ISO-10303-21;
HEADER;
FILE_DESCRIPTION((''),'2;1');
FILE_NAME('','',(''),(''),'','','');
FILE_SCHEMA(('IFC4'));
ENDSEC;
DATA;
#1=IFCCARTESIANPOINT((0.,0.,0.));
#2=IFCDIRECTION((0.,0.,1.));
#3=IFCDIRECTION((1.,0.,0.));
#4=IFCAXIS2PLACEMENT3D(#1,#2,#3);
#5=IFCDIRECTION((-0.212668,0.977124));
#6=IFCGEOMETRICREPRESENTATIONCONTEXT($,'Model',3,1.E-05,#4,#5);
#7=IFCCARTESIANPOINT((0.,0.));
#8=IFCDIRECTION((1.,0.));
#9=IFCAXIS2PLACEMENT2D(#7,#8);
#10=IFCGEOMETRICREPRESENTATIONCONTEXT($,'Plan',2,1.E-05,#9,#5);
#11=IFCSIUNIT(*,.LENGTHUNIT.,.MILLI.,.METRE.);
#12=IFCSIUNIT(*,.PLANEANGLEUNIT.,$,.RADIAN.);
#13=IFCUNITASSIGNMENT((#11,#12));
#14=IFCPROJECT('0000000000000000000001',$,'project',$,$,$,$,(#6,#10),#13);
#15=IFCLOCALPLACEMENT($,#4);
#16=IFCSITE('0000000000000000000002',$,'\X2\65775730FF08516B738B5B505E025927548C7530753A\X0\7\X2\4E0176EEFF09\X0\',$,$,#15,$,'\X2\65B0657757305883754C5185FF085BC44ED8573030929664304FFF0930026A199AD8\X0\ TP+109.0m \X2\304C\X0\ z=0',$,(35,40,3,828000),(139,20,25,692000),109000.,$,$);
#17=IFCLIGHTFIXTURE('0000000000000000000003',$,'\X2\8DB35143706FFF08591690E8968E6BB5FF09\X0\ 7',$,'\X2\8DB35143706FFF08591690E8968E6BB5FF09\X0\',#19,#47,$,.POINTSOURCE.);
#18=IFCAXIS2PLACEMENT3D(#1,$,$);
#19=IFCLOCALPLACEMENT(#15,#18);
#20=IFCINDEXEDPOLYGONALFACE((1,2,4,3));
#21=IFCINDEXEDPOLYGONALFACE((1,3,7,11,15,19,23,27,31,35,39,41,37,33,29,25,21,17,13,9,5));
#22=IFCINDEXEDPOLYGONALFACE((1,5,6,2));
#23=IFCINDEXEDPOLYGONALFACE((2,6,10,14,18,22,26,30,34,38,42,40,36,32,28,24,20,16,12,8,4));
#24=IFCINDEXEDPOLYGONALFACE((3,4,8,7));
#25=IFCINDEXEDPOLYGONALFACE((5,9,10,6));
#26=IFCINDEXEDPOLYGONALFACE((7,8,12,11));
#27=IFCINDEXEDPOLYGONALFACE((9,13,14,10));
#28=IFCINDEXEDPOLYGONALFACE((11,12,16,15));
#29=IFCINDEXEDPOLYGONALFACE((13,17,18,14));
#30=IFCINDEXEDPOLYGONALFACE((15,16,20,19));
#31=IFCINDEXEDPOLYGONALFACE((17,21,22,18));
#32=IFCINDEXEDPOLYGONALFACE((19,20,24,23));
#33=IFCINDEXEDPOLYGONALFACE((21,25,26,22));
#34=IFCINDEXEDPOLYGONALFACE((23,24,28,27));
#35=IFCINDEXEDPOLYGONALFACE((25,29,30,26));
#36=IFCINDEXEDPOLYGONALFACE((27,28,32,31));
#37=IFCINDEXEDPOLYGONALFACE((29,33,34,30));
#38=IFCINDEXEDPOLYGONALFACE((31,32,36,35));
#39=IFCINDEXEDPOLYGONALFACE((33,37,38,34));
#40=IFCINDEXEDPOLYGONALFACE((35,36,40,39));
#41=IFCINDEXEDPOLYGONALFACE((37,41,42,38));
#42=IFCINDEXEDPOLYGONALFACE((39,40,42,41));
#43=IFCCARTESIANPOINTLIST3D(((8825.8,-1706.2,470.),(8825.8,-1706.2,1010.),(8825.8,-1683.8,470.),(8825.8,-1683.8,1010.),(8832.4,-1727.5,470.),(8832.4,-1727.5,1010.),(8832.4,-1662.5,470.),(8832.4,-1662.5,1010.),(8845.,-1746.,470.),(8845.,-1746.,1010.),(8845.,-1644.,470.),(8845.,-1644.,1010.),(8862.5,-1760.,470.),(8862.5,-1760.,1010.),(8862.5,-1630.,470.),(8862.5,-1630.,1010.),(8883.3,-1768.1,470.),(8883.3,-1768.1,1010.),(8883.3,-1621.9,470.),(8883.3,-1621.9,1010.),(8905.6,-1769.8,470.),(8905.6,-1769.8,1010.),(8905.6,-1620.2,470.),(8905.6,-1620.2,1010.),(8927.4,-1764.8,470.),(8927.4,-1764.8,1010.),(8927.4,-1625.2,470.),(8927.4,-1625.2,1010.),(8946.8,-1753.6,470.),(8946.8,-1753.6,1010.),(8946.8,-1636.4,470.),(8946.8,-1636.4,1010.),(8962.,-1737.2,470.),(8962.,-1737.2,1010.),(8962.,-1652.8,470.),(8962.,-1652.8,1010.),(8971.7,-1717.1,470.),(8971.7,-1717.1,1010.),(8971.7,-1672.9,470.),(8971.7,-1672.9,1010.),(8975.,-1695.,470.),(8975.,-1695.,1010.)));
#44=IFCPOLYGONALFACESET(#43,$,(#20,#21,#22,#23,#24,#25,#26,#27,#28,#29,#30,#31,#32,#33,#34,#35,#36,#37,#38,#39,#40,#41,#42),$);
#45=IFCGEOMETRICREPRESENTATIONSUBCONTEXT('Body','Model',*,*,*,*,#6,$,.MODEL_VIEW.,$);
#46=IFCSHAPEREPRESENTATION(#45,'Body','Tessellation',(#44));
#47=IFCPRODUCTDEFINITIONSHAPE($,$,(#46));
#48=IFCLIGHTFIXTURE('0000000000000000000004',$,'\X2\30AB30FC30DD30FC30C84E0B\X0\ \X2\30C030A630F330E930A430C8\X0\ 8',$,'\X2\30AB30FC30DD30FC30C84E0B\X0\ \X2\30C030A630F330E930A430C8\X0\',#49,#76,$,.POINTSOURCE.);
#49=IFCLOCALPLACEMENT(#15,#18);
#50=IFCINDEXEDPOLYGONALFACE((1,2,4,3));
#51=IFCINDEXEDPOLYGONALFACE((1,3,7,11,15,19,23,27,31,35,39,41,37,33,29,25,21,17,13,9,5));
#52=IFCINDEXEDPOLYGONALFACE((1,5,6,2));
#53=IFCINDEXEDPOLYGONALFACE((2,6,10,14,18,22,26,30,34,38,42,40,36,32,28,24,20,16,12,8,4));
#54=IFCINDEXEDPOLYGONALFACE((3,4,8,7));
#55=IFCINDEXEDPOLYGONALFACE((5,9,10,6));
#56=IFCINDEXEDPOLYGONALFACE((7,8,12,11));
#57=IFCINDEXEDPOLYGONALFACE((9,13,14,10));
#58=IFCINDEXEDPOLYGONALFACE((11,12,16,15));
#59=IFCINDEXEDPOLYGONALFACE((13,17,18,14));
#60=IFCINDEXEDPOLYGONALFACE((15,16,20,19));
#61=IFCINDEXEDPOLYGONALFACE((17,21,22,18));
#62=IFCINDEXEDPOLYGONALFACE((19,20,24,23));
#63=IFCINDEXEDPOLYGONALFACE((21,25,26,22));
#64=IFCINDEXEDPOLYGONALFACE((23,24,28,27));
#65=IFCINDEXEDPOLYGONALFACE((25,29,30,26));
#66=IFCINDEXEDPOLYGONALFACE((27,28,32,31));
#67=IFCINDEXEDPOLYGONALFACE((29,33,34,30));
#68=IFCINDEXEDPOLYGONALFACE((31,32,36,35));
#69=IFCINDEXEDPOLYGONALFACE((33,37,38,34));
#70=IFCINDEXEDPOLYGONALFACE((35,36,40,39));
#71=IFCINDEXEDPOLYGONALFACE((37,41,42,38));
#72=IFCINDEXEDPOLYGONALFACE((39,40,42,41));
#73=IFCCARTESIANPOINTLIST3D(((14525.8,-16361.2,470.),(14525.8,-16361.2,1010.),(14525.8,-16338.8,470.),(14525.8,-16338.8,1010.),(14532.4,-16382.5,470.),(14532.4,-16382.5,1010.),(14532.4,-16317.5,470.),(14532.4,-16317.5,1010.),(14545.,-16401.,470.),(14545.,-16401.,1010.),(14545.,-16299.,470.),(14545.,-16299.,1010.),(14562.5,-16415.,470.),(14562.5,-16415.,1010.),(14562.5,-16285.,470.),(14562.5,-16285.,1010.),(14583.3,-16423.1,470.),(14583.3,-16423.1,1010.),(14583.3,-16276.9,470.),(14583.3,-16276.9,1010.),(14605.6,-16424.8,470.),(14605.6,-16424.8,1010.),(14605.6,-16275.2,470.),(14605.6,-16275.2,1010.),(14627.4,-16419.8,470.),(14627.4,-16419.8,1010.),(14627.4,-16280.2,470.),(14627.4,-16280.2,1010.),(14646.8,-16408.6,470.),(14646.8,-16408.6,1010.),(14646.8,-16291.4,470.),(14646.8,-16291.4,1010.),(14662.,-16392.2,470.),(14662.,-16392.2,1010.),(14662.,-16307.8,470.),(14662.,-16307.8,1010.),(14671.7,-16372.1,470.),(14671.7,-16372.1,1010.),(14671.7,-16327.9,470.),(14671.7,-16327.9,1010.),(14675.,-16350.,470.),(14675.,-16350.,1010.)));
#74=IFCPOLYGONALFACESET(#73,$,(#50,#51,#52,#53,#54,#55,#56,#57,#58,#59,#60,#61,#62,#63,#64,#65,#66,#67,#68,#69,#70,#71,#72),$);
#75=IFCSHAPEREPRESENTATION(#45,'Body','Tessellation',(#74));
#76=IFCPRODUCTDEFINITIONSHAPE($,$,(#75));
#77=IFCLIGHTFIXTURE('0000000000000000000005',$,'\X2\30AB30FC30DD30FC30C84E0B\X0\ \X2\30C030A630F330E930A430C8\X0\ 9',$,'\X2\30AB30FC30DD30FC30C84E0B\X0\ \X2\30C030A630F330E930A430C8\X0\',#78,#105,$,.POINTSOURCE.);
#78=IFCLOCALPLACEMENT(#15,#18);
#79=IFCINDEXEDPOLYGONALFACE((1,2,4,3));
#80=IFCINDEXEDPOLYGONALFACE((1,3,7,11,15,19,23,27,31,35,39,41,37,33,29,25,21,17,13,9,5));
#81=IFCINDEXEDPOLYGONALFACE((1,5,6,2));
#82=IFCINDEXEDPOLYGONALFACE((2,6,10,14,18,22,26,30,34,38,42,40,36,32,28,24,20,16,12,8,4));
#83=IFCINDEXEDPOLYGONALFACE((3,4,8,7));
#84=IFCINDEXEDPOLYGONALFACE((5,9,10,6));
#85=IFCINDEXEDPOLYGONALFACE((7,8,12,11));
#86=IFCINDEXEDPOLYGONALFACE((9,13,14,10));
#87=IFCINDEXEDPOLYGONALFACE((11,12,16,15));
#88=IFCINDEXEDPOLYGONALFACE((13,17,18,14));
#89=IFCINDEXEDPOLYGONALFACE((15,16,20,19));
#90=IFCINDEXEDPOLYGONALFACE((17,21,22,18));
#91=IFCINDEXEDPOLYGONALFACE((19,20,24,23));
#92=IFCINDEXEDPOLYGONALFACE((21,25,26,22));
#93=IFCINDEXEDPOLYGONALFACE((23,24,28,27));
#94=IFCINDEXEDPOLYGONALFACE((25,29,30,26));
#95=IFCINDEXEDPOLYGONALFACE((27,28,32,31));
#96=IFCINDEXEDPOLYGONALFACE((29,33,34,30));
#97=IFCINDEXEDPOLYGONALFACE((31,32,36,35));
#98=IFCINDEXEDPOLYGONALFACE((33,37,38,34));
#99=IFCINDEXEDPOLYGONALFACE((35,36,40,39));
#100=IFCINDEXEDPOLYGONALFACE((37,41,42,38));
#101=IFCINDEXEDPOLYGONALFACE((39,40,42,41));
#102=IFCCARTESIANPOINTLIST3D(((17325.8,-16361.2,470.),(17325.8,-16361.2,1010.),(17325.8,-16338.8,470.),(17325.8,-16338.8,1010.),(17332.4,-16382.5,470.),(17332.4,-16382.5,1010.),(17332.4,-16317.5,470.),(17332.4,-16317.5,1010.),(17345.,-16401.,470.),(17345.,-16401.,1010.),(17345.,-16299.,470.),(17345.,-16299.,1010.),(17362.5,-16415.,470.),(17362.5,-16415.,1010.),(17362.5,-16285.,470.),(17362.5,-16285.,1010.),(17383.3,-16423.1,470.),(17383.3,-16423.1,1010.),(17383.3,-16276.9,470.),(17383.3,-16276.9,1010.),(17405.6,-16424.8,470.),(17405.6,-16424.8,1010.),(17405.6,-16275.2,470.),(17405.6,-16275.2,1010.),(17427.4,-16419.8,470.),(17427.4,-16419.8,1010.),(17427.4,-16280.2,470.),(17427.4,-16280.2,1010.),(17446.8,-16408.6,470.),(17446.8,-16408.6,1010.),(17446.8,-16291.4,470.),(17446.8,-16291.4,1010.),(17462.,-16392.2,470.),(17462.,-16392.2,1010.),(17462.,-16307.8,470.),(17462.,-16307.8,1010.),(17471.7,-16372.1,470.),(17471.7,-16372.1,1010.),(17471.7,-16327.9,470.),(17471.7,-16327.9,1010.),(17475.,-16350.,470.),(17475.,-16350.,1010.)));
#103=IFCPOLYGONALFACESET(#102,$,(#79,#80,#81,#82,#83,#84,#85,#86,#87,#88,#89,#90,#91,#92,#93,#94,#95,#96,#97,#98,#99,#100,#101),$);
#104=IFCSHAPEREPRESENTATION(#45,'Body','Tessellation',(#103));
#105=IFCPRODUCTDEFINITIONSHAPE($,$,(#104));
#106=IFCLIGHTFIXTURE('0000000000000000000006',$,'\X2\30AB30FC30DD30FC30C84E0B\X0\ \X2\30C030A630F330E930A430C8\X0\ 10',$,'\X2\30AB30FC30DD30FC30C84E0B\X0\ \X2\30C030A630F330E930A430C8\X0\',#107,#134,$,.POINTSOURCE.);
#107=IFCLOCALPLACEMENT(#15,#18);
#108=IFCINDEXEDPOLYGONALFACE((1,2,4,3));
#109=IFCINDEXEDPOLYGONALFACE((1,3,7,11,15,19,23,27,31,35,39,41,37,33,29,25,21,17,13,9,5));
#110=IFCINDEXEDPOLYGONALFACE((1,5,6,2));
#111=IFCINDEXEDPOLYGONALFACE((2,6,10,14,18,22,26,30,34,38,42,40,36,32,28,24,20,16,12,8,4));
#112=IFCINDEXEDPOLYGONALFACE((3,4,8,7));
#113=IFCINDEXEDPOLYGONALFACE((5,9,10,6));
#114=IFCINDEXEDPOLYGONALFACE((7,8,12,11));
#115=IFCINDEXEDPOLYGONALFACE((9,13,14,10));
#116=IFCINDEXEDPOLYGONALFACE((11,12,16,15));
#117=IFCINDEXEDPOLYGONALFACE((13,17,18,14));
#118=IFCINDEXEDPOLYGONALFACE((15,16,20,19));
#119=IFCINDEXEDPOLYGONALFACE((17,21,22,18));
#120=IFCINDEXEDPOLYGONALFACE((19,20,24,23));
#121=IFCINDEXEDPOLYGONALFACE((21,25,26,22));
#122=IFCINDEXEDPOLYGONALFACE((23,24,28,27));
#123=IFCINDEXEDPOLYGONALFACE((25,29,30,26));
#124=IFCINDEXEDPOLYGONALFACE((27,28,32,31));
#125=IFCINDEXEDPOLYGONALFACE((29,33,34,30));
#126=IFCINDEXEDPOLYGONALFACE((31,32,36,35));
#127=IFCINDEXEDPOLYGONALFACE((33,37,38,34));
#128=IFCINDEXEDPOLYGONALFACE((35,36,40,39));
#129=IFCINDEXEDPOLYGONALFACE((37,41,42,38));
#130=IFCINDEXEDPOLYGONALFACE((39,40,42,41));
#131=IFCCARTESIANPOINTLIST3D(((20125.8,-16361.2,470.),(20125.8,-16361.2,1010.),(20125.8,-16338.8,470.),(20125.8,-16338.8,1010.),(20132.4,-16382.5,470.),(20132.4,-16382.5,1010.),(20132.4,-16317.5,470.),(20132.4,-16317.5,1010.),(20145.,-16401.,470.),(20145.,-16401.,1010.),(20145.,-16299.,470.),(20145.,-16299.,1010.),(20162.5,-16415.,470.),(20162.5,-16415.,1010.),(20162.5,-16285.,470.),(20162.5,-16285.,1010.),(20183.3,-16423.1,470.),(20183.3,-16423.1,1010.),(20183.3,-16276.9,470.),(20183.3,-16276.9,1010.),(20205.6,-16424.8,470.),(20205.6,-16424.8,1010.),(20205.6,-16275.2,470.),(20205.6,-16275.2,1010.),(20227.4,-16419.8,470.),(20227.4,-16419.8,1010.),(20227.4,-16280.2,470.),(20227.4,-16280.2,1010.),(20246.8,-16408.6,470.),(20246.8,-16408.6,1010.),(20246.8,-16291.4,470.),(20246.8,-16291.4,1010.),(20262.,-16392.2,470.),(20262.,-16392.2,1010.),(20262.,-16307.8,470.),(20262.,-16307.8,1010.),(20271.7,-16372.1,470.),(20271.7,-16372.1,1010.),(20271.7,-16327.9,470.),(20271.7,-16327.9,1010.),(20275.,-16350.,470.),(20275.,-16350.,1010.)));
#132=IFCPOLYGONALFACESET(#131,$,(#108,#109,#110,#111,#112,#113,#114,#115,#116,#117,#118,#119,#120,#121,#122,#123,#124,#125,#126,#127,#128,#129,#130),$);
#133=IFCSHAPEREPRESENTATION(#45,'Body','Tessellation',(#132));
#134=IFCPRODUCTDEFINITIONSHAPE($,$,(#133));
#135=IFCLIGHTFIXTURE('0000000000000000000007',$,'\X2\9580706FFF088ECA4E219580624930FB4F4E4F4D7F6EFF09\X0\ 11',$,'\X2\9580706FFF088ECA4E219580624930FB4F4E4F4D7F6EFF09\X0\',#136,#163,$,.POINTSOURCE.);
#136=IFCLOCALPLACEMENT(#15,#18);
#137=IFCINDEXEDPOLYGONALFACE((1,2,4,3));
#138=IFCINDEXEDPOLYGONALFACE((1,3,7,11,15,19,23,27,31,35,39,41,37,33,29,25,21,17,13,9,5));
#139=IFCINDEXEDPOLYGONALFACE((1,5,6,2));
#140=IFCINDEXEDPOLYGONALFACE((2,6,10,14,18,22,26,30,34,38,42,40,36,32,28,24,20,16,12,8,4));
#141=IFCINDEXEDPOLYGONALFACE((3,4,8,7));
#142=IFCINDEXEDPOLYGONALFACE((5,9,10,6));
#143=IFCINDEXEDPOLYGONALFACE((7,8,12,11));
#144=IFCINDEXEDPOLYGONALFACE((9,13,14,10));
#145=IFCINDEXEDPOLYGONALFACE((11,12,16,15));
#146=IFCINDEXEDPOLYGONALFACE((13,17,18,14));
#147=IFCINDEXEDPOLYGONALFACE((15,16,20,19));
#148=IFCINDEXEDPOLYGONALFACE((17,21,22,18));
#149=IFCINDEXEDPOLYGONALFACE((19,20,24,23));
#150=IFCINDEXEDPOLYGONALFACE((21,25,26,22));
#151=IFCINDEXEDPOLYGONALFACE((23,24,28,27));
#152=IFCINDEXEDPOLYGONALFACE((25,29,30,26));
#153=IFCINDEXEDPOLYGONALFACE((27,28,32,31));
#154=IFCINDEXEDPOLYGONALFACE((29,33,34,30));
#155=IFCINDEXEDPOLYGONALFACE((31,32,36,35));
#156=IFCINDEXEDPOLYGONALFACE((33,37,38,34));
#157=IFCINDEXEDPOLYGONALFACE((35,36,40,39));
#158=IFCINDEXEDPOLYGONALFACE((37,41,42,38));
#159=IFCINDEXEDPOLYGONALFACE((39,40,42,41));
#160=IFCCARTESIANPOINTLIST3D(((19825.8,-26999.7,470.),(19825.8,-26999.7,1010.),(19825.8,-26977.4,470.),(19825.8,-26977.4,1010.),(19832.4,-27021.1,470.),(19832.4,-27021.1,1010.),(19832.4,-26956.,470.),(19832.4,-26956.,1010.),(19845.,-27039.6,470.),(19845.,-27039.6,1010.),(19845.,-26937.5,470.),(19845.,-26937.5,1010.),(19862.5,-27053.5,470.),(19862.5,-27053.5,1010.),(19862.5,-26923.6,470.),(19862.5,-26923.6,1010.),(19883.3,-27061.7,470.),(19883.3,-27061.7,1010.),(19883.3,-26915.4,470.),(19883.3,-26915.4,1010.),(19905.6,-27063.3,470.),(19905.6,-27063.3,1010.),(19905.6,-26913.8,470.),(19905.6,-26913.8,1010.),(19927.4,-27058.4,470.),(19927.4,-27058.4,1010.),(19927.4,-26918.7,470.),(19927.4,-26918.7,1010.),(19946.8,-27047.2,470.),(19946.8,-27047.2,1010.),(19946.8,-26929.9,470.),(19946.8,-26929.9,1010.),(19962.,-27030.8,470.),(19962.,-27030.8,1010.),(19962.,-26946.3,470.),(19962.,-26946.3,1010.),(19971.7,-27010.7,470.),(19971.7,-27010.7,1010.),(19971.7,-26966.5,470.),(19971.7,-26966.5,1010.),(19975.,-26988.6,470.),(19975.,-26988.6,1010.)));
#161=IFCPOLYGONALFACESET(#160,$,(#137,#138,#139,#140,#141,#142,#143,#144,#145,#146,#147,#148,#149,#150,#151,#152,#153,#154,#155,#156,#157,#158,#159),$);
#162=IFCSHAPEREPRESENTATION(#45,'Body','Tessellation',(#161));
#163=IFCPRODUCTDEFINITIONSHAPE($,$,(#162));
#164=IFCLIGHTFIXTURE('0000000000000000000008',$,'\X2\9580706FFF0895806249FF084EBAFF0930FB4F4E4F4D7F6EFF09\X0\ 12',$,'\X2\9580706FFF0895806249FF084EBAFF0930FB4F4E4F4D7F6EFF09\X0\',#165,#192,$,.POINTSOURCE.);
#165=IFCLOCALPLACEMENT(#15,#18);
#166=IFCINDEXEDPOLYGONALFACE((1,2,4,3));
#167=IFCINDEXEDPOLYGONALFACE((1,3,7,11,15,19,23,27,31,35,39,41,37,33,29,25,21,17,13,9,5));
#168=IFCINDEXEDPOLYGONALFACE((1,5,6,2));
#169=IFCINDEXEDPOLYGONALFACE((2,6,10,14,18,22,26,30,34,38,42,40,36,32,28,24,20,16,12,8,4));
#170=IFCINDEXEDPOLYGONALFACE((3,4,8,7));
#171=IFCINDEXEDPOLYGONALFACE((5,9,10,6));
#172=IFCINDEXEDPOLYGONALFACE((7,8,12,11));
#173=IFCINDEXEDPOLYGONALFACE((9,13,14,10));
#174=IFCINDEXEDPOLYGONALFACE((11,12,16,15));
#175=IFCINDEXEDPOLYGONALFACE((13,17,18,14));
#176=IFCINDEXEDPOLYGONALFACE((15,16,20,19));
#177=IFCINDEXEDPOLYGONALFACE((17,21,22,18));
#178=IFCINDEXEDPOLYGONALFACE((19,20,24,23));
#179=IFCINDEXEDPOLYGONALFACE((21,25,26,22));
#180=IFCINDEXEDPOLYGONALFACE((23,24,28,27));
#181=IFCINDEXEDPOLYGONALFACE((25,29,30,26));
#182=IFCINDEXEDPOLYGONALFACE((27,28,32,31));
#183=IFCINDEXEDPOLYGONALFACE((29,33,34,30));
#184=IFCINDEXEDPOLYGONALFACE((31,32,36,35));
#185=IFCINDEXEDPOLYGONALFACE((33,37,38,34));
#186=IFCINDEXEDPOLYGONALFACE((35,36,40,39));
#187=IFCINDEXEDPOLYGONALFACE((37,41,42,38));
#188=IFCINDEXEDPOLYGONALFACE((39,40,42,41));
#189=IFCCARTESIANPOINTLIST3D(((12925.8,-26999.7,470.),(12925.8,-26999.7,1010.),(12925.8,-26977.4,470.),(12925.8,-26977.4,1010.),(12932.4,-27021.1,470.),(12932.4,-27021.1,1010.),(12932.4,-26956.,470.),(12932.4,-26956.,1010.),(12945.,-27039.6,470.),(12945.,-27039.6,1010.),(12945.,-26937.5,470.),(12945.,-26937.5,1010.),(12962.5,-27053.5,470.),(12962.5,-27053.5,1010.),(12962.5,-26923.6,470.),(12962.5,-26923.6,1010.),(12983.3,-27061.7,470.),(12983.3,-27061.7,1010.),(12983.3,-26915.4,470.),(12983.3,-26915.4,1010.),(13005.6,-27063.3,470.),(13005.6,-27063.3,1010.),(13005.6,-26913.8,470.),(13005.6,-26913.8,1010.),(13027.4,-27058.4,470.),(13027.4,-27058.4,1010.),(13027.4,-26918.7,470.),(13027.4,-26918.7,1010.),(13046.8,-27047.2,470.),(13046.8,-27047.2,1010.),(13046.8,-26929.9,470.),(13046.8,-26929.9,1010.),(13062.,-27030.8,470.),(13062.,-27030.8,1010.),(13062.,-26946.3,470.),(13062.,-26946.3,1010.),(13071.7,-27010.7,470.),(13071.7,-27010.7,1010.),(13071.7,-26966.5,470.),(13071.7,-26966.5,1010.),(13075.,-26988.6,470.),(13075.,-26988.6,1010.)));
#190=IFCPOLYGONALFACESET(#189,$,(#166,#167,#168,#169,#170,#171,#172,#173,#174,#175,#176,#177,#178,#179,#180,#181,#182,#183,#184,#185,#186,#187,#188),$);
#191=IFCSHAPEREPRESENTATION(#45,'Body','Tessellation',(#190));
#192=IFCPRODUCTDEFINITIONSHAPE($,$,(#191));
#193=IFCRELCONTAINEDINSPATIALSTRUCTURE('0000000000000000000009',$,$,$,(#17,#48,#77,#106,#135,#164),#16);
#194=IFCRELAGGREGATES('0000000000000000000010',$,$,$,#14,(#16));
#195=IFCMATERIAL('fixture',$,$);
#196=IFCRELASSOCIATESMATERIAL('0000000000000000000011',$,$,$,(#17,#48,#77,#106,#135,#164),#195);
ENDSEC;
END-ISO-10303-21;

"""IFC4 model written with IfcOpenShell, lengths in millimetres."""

from ifc_helpers import new_model, si_unit, direction, frame, frame_2d, origin_with_axes, origin_2d_with_axis, place, context, subcontext, project, spatial, circle, extrude, material, element, save


model = new_model("IFC4")

# Units and contexts
model_context = context("Model", 3, precision=1e-05, world=origin_with_axes(), true_north=direction((-0.212668, 0.977124)))
plan_context = context("Plan", 2, precision=1e-05, world=origin_2d_with_axis(), true_north=direction((-0.212668, 0.977124)))
body_context = subcontext(model_context, "Body", "Model", "MODEL_VIEW")
ifc_project = project(units=[si_unit("LENGTHUNIT", "METRE", prefix="MILLI"), si_unit("PLANEANGLEUNIT", "RADIAN")], contexts=[model_context, plan_context])

# Site
site_placement = place(None, origin_with_axes())
site = spatial("IfcSite", under=ifc_project, at=site_placement, Name="敷地（八王子市大和田町7丁目）", LongName="新敷地境界内（寄付地を除く）。標高 TP+109.0m が z=0", RefLatitude=(35, 40, 3, 828000), RefLongitude=(139, 20, 25, 692000), RefElevation=109000.0)

# Light fixtures
ifc_material_1 = material(Name="fixture")
light_fixture_1_placement = place(site_placement, origin_with_axes())
element("IfcLightFixture", 1, at=light_fixture_1_placement, inside=site, material=ifc_material_1, Name="足元灯（外部階段） 7", ObjectType="足元灯（外部階段）", PredefinedType="POINTSOURCE", context=body_context, shape_type="SweptSolid", body=[
    extrude(circle(Radius=75.0, at=frame_2d((8900.0, -1695.0))), frame((0.0, 0.0, 470.0)), (0.0, 0.0, 1.0), 540.0),
])
light_fixture_2_placement = place(site_placement, origin_with_axes())
element("IfcLightFixture", 2, at=light_fixture_2_placement, inside=site, material=ifc_material_1, Name="カーポート下 ダウンライト 8", ObjectType="カーポート下 ダウンライト", PredefinedType="POINTSOURCE", context=body_context, shape_type="SweptSolid", body=[
    extrude(circle(Radius=75.0, at=frame_2d((14600.0, -16350.0))), frame((0.0, 0.0, 470.0)), (0.0, 0.0, 1.0), 540.0),
])
light_fixture_3_placement = place(site_placement, origin_with_axes())
element("IfcLightFixture", 3, at=light_fixture_3_placement, inside=site, material=ifc_material_1, Name="カーポート下 ダウンライト 9", ObjectType="カーポート下 ダウンライト", PredefinedType="POINTSOURCE", context=body_context, shape_type="SweptSolid", body=[
    extrude(circle(Radius=75.0, at=frame_2d((17400.0, -16350.0))), frame((0.0, 0.0, 470.0)), (0.0, 0.0, 1.0), 540.0),
])
light_fixture_4_placement = place(site_placement, origin_with_axes())
element("IfcLightFixture", 4, at=light_fixture_4_placement, inside=site, material=ifc_material_1, Name="カーポート下 ダウンライト 10", ObjectType="カーポート下 ダウンライト", PredefinedType="POINTSOURCE", context=body_context, shape_type="SweptSolid", body=[
    extrude(circle(Radius=75.0, at=frame_2d((20200.0, -16350.0))), frame((0.0, 0.0, 470.0)), (0.0, 0.0, 1.0), 540.0),
])
light_fixture_5_placement = place(site_placement, origin_with_axes())
element("IfcLightFixture", 5, at=light_fixture_5_placement, inside=site, material=ifc_material_1, Name="門灯（車両門扉・低位置） 11", ObjectType="門灯（車両門扉・低位置）", PredefinedType="POINTSOURCE", context=body_context, shape_type="SweptSolid", body=[
    extrude(circle(Radius=75.0, at=frame_2d((19900.0, -26988.6))), frame((0.0, 0.0, 470.0)), (0.0, 0.0, 1.0), 540.0),
])
light_fixture_6_placement = place(site_placement, origin_with_axes())
element("IfcLightFixture", 6, at=light_fixture_6_placement, inside=site, material=ifc_material_1, Name="門灯（門扉（人）・低位置） 12", ObjectType="門灯（門扉（人）・低位置）", PredefinedType="POINTSOURCE", context=body_context, shape_type="SweptSolid", body=[
    extrude(circle(Radius=75.0, at=frame_2d((13000.0, -26988.6))), frame((0.0, 0.0, 470.0)), (0.0, 0.0, 1.0), 540.0),
])

save(model, "model.ifc")
